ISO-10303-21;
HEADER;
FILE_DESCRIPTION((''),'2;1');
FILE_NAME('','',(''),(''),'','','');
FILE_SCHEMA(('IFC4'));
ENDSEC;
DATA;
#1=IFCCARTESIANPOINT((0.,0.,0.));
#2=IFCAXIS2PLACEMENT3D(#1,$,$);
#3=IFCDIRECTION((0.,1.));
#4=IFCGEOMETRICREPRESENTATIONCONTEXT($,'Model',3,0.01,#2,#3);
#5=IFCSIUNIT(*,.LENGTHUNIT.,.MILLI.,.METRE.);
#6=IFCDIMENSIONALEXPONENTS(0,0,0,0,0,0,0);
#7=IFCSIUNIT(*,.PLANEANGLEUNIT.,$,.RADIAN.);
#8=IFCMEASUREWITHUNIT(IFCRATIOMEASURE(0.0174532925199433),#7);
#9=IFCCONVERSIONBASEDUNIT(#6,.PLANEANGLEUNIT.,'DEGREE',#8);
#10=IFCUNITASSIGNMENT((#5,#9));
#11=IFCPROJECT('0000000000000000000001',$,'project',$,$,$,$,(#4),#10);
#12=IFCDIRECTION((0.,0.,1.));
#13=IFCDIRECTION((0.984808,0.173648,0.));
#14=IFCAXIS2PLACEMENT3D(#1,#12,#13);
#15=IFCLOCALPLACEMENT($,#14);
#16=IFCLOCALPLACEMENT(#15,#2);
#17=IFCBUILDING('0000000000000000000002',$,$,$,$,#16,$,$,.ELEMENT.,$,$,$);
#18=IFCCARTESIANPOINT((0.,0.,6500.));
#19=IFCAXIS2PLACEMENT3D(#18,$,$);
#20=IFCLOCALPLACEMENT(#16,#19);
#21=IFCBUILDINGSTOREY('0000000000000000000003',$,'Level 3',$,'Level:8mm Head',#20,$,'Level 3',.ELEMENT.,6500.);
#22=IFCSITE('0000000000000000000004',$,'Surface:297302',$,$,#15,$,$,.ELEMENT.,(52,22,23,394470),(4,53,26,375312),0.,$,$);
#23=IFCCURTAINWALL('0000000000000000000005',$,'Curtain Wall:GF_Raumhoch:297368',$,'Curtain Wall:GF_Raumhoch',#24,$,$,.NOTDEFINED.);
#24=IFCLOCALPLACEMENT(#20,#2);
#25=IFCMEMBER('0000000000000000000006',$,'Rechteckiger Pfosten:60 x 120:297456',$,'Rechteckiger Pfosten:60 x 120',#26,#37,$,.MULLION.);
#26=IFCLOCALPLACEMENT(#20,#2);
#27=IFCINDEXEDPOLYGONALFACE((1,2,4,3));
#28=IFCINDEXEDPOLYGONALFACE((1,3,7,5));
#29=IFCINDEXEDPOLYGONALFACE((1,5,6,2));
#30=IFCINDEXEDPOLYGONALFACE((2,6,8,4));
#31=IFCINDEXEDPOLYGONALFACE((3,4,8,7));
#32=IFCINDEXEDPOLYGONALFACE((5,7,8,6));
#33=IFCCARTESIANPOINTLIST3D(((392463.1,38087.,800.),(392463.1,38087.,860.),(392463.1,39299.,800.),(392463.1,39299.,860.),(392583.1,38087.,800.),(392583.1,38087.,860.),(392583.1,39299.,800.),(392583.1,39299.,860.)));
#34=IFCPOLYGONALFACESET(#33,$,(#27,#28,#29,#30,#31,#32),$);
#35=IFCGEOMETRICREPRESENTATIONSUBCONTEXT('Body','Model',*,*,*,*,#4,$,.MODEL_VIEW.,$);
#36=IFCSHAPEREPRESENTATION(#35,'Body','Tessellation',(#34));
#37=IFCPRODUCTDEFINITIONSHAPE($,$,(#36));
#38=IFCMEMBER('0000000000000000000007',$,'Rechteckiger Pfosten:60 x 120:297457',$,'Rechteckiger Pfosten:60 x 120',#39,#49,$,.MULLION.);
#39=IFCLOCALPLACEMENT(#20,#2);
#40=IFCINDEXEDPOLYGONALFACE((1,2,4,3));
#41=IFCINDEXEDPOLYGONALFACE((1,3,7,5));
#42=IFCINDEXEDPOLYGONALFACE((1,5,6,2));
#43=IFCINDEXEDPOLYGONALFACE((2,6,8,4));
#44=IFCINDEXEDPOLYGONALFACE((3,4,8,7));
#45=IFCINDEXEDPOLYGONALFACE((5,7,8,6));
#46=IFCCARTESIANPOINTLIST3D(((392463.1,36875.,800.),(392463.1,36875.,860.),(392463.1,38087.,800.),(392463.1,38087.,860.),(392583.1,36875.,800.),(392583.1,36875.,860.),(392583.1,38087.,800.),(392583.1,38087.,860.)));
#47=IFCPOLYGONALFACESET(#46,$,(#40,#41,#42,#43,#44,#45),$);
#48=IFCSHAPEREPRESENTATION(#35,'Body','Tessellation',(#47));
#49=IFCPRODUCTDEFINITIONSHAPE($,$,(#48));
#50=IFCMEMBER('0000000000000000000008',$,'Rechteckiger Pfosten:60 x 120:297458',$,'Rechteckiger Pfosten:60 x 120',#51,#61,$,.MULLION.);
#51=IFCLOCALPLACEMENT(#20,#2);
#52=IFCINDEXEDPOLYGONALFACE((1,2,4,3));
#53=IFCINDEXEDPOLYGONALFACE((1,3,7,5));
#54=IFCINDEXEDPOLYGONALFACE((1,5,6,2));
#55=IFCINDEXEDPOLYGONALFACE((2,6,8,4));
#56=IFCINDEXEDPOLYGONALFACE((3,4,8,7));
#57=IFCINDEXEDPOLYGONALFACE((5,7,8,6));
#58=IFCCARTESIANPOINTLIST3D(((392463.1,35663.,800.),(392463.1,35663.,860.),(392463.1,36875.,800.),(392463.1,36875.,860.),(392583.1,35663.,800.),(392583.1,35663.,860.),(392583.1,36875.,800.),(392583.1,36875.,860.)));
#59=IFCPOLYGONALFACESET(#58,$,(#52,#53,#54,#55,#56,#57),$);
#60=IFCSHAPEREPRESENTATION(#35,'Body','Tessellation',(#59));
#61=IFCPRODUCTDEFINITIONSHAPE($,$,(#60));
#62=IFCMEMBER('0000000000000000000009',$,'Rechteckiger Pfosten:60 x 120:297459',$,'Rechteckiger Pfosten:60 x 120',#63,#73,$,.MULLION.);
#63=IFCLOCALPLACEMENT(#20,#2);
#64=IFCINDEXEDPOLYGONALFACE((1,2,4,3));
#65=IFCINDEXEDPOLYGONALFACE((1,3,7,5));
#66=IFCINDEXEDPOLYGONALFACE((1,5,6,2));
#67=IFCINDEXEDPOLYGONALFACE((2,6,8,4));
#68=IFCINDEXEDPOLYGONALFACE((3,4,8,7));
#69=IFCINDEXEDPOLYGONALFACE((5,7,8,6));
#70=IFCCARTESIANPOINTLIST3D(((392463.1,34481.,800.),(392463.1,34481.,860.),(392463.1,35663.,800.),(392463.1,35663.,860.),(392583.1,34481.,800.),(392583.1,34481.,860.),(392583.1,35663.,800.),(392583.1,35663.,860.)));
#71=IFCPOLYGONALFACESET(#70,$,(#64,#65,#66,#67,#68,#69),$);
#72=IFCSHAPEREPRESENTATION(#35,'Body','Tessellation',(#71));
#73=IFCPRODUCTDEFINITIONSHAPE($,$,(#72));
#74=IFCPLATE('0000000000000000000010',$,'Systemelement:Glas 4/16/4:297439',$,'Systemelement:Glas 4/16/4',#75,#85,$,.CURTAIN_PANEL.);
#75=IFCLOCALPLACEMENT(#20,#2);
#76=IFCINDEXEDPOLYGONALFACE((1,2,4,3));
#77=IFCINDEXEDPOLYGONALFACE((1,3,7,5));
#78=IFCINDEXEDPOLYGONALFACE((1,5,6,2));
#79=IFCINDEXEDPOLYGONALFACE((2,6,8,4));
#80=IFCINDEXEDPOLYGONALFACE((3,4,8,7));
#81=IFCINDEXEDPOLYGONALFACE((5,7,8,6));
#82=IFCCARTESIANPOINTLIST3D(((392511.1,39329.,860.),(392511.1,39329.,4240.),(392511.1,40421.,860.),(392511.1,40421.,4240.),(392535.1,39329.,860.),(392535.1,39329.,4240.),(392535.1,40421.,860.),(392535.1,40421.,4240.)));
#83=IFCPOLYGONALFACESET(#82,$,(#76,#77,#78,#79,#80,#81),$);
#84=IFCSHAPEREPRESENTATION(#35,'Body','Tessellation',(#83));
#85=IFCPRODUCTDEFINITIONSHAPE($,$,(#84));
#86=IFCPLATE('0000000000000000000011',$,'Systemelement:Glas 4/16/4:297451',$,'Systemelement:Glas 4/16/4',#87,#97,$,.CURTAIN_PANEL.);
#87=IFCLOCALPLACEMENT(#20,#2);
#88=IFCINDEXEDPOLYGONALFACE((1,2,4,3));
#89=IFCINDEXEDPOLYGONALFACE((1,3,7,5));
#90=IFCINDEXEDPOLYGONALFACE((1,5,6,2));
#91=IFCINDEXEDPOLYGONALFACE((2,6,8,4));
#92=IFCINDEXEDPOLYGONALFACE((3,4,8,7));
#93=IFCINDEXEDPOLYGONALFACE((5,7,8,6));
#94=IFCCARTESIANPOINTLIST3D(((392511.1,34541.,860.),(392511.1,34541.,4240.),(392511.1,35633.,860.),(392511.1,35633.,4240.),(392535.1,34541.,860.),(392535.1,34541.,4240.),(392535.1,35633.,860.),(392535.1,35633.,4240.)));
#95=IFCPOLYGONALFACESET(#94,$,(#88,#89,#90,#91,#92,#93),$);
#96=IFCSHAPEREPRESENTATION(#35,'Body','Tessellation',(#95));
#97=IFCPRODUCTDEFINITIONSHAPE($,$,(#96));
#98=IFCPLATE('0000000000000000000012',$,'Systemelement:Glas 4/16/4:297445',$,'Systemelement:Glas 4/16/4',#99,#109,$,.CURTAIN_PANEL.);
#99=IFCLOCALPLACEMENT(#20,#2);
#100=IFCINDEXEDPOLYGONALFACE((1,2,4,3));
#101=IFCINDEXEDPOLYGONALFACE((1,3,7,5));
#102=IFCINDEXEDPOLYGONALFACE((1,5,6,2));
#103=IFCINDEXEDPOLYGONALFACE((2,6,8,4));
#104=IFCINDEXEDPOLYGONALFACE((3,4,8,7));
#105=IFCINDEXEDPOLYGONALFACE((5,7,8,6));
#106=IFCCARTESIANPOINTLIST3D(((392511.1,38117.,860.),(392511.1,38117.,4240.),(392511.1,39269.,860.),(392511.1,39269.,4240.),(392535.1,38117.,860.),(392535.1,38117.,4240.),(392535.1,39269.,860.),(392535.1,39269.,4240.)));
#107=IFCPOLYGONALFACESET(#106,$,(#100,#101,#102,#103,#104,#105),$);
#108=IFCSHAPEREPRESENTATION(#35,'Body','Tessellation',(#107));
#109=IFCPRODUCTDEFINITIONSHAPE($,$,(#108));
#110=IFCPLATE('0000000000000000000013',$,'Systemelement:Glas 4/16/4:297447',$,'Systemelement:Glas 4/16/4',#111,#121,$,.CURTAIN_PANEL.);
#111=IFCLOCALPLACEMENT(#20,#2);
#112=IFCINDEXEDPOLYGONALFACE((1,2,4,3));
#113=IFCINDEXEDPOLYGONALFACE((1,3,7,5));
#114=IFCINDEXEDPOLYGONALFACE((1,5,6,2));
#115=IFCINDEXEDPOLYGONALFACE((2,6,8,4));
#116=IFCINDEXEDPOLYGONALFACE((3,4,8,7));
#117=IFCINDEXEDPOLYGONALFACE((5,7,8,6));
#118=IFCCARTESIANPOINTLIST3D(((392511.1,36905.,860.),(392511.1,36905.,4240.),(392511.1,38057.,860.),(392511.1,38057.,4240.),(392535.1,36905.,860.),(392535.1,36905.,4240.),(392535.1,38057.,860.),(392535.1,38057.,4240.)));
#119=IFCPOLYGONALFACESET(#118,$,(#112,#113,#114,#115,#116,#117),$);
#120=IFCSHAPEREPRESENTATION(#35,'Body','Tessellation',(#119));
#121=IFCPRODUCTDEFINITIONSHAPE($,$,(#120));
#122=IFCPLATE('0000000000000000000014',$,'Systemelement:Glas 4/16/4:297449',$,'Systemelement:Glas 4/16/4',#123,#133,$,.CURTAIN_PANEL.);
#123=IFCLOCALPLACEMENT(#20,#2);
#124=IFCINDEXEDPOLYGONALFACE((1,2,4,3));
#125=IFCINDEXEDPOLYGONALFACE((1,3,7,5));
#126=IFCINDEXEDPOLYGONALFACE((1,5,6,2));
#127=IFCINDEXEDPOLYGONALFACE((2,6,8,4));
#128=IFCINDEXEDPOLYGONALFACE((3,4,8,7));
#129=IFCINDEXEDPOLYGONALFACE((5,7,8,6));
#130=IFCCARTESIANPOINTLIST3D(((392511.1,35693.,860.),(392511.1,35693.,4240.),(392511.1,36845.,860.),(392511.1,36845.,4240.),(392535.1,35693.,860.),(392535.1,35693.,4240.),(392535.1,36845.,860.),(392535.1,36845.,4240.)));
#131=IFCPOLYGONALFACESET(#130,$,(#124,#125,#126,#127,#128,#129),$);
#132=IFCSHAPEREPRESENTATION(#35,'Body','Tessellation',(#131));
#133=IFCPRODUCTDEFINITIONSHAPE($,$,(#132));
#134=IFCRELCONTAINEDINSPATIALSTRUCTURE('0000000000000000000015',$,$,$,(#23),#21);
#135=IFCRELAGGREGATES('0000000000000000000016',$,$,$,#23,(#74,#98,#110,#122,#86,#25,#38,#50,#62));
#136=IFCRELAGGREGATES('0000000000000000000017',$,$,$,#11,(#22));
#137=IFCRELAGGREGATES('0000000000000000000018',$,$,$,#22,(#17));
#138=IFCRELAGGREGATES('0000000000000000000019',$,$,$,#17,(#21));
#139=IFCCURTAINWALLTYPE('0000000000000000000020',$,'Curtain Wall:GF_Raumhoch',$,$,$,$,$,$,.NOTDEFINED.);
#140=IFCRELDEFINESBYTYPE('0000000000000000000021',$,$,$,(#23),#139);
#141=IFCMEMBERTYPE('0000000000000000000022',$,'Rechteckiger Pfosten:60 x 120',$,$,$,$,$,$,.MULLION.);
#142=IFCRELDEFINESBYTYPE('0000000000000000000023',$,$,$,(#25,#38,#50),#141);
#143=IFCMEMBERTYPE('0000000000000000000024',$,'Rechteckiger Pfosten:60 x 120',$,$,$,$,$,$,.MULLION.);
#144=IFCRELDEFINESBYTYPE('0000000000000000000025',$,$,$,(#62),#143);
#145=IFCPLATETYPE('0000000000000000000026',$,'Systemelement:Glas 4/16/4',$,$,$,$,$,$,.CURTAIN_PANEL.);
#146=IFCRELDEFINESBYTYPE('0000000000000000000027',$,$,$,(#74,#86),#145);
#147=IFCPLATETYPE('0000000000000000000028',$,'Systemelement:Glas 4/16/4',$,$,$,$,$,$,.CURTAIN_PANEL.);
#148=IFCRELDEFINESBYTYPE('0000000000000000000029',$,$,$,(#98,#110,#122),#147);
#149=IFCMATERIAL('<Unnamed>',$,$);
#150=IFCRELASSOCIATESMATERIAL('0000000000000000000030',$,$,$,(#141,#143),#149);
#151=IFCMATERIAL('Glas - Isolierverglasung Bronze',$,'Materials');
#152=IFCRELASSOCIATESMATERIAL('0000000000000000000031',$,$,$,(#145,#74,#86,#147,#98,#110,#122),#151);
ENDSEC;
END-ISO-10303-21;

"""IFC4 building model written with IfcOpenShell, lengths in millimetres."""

from ifc_helpers import new_model, entity, si_unit, converted_unit, direction, frame, origin, place, context, subcontext, project, spatial, indexed_curve, outline, extrude, source, transform, mapped, material, type_object, type_shapes, element, aggregate, save


model = new_model("IFC4")

# Units and contexts
model_context = context("Model", 3, precision=0.01, world=origin(), true_north=direction((0.0, 1.0)))
body_context = subcontext(model_context, "Body", "Model", "MODEL_VIEW")
ifc_project = project(units=[si_unit("LENGTHUNIT", "METRE", prefix="MILLI"), converted_unit("PLANEANGLEUNIT", "DEGREE", entity("IfcRatioMeasure", 0.0174532925199433), si_unit("PLANEANGLEUNIT", "RADIAN"), dimensions=[0, 0, 0, 0, 0, 0, 0])], contexts=[model_context])

# Site, building, storey
site_placement = place(None, frame((0.0, 0.0, 0.0), z_axis=(0.0, 0.0, 1.0), x_axis=(0.984808, 0.173648, 0.0)))
site = spatial("IfcSite", under=ifc_project, at=site_placement, Name="Surface:297302", CompositionType="ELEMENT", RefLatitude=(52, 22, 23, 394470), RefLongitude=(4, 53, 26, 375312), RefElevation=0.0)
building_placement = place(site_placement, origin())
building = spatial("IfcBuilding", under=site, at=building_placement, CompositionType="ELEMENT")
storey_placement = place(building_placement, frame((0.0, 0.0, 6500.0)))
storey = spatial("IfcBuildingStorey", under=building, at=storey_placement, Name="Level 3", ObjectType="Level:8mm Head", LongName="Level 3", CompositionType="ELEMENT", Elevation=6500.0)

# Curtain wall, members
curtain_wall_type = type_object("IfcCurtainWallType", Name="Curtain Wall:GF_Raumhoch", PredefinedType="NOTDEFINED")
curtain_wall_placement = place(storey_placement, frame((0.0, 0.0, -6500.0)))
curtain_wall = element("IfcCurtainWall", 1, at=curtain_wall_placement, inside=storey, type_object=curtain_wall_type, Name="Curtain Wall:GF_Raumhoch:297368", ObjectType="Curtain Wall:GF_Raumhoch", PredefinedType="NOTDEFINED")
ifc_material_1 = material(Name="<Unnamed>")
member_type_1 = type_object("IfcMemberType", Name="Rechteckiger Pfosten:60 x 120", PredefinedType="MULLION", material=ifc_material_1)
shared_shape_1 = source(origin(), body_context, "Body", "SweptSolid", [
    extrude(outline(indexed_curve([(-60.0, -30.0), (60.0, -30.0), (60.0, 30.0), (-60.0, 30.0), (-60.0, -30.0)], self_intersect=False)), frame((-30.0, 0.0, -1212.0), z_axis=(0.0, 0.0, 1.0), x_axis=(0.0, -1.0, 0.0)), (0.0, 0.0, 1.0), 1212.0),
])
type_shapes(member_type_1, [shared_shape_1])
member_1_placement = place(curtain_wall_placement, frame((392523.1, 39299.0, 7300.0), z_axis=(0.0, 1.0, 0.0), x_axis=(0.0, 0.0, -1.0)))
member_1 = element("IfcMember", 2, at=member_1_placement, type_object=member_type_1, Name="Rechteckiger Pfosten:60 x 120:297456", ObjectType="Rechteckiger Pfosten:60 x 120", PredefinedType="MULLION", context=body_context, shape_type="MappedRepresentation", body=[
    mapped(shared_shape_1, transform((0.0, 0.0, 0.0), scale=1.0)),
])
member_2_placement = place(curtain_wall_placement, frame((392523.1, 38087.0, 7300.0), z_axis=(0.0, 1.0, 0.0), x_axis=(0.0, 0.0, -1.0)))
member_2 = element("IfcMember", 3, at=member_2_placement, type_object=member_type_1, Name="Rechteckiger Pfosten:60 x 120:297457", ObjectType="Rechteckiger Pfosten:60 x 120", PredefinedType="MULLION", context=body_context, shape_type="MappedRepresentation", body=[
    mapped(shared_shape_1, transform((0.0, 0.0, 0.0), scale=1.0)),
])
member_3_placement = place(curtain_wall_placement, frame((392523.1, 36875.0, 7300.0), z_axis=(0.0, 1.0, 0.0), x_axis=(0.0, 0.0, -1.0)))
member_3 = element("IfcMember", 4, at=member_3_placement, type_object=member_type_1, Name="Rechteckiger Pfosten:60 x 120:297458", ObjectType="Rechteckiger Pfosten:60 x 120", PredefinedType="MULLION", context=body_context, shape_type="MappedRepresentation", body=[
    mapped(shared_shape_1, transform((0.0, 0.0, 0.0), scale=1.0)),
])
member_type_2 = type_object("IfcMemberType", Name="Rechteckiger Pfosten:60 x 120", PredefinedType="MULLION", material=ifc_material_1)
shared_shape_2 = source(origin(), body_context, "Body", "SweptSolid", [
    extrude(outline(indexed_curve([(-60.0, -30.0), (60.0, -30.0), (60.0, 30.0), (-60.0, 30.0), (-60.0, -30.0)], self_intersect=False)), frame((-30.0, 0.0, -1182.0), z_axis=(0.0, 0.0, 1.0), x_axis=(0.0, -1.0, 0.0)), (0.0, 0.0, 1.0), 1182.0),
])
type_shapes(member_type_2, [shared_shape_2])
member_4_placement = place(curtain_wall_placement, frame((392523.1, 35663.0, 7300.0), z_axis=(0.0, 1.0, 0.0), x_axis=(0.0, 0.0, -1.0)))
member_4 = element("IfcMember", 5, at=member_4_placement, type_object=member_type_2, Name="Rechteckiger Pfosten:60 x 120:297459", ObjectType="Rechteckiger Pfosten:60 x 120", PredefinedType="MULLION", context=body_context, shape_type="MappedRepresentation", body=[
    mapped(shared_shape_2, transform((0.0, 0.0, 0.0), scale=1.0)),
])

# Plates
ifc_material_2 = material(Name="Glas - Isolierverglasung Bronze", Category="Materials")
plate_type_1 = type_object("IfcPlateType", Name="Systemelement:Glas 4/16/4", PredefinedType="CURTAIN_PANEL", material=ifc_material_2)
shared_shape_3 = source(origin(), body_context, "Body", "SweptSolid", [
    extrude(outline(indexed_curve([(-12.0, -546.0), (12.0, -546.0), (12.0, 546.0), (-12.0, 546.0), (-12.0, -546.0)], self_intersect=False)), frame((0.0, 0.0, 0.0), z_axis=(0.0, 0.0, 1.0), x_axis=(0.0, 1.0, 0.0)), (0.0, 0.0, 1.0), 3380.0),
])
type_shapes(plate_type_1, [shared_shape_3])
plate_1_placement = place(curtain_wall_placement, frame((392523.1, 39875.0, 7360.0), z_axis=(0.0, 0.0, 1.0), x_axis=(0.0, -1.0, 0.0)))
plate_1 = element("IfcPlate", 6, at=plate_1_placement, type_object=plate_type_1, material=ifc_material_2, Name="Systemelement:Glas 4/16/4:297439", ObjectType="Systemelement:Glas 4/16/4", PredefinedType="CURTAIN_PANEL", context=body_context, shape_type="MappedRepresentation", body=[
    mapped(shared_shape_3, transform((0.0, 0.0, 0.0), scale=1.0)),
])
plate_2_placement = place(curtain_wall_placement, frame((392523.1, 35087.0, 7360.0), z_axis=(0.0, 0.0, 1.0), x_axis=(0.0, -1.0, 0.0)))
plate_2 = element("IfcPlate", 7, at=plate_2_placement, type_object=plate_type_1, material=ifc_material_2, Name="Systemelement:Glas 4/16/4:297451", ObjectType="Systemelement:Glas 4/16/4", PredefinedType="CURTAIN_PANEL", context=body_context, shape_type="MappedRepresentation", body=[
    mapped(shared_shape_3, transform((0.0, 0.0, 0.0), scale=1.0)),
])
plate_type_2 = type_object("IfcPlateType", Name="Systemelement:Glas 4/16/4", PredefinedType="CURTAIN_PANEL", material=ifc_material_2)
shared_shape_4 = source(origin(), body_context, "Body", "SweptSolid", [
    extrude(outline(indexed_curve([(-12.0, -576.0), (12.0, -576.0), (12.0, 576.0), (-12.0, 576.0), (-12.0, -576.0)], self_intersect=False)), frame((0.0, 0.0, 0.0), z_axis=(0.0, 0.0, 1.0), x_axis=(0.0, 1.0, 0.0)), (0.0, 0.0, 1.0), 3380.0),
])
type_shapes(plate_type_2, [shared_shape_4])
plate_3_placement = place(curtain_wall_placement, frame((392523.1, 38693.0, 7360.0), z_axis=(0.0, 0.0, 1.0), x_axis=(0.0, -1.0, 0.0)))
plate_3 = element("IfcPlate", 8, at=plate_3_placement, type_object=plate_type_2, material=ifc_material_2, Name="Systemelement:Glas 4/16/4:297445", ObjectType="Systemelement:Glas 4/16/4", PredefinedType="CURTAIN_PANEL", context=body_context, shape_type="MappedRepresentation", body=[
    mapped(shared_shape_4, transform((0.0, 0.0, 0.0), scale=1.0)),
])
plate_4_placement = place(curtain_wall_placement, frame((392523.1, 37481.0, 7360.0), z_axis=(0.0, 0.0, 1.0), x_axis=(0.0, -1.0, 0.0)))
plate_4 = element("IfcPlate", 9, at=plate_4_placement, type_object=plate_type_2, material=ifc_material_2, Name="Systemelement:Glas 4/16/4:297447", ObjectType="Systemelement:Glas 4/16/4", PredefinedType="CURTAIN_PANEL", context=body_context, shape_type="MappedRepresentation", body=[
    mapped(shared_shape_4, transform((0.0, 0.0, 0.0), scale=1.0)),
])
plate_5_placement = place(curtain_wall_placement, frame((392523.1, 36269.0, 7360.0), z_axis=(0.0, 0.0, 1.0), x_axis=(0.0, -1.0, 0.0)))
plate_5 = element("IfcPlate", 10, at=plate_5_placement, type_object=plate_type_2, material=ifc_material_2, Name="Systemelement:Glas 4/16/4:297449", ObjectType="Systemelement:Glas 4/16/4", PredefinedType="CURTAIN_PANEL", context=body_context, shape_type="MappedRepresentation", body=[
    mapped(shared_shape_4, transform((0.0, 0.0, 0.0), scale=1.0)),
])
aggregate(curtain_wall, [plate_1, plate_3, plate_4, plate_5, plate_2, member_1, member_2, member_3, member_4])

save(model, "model.ifc")
